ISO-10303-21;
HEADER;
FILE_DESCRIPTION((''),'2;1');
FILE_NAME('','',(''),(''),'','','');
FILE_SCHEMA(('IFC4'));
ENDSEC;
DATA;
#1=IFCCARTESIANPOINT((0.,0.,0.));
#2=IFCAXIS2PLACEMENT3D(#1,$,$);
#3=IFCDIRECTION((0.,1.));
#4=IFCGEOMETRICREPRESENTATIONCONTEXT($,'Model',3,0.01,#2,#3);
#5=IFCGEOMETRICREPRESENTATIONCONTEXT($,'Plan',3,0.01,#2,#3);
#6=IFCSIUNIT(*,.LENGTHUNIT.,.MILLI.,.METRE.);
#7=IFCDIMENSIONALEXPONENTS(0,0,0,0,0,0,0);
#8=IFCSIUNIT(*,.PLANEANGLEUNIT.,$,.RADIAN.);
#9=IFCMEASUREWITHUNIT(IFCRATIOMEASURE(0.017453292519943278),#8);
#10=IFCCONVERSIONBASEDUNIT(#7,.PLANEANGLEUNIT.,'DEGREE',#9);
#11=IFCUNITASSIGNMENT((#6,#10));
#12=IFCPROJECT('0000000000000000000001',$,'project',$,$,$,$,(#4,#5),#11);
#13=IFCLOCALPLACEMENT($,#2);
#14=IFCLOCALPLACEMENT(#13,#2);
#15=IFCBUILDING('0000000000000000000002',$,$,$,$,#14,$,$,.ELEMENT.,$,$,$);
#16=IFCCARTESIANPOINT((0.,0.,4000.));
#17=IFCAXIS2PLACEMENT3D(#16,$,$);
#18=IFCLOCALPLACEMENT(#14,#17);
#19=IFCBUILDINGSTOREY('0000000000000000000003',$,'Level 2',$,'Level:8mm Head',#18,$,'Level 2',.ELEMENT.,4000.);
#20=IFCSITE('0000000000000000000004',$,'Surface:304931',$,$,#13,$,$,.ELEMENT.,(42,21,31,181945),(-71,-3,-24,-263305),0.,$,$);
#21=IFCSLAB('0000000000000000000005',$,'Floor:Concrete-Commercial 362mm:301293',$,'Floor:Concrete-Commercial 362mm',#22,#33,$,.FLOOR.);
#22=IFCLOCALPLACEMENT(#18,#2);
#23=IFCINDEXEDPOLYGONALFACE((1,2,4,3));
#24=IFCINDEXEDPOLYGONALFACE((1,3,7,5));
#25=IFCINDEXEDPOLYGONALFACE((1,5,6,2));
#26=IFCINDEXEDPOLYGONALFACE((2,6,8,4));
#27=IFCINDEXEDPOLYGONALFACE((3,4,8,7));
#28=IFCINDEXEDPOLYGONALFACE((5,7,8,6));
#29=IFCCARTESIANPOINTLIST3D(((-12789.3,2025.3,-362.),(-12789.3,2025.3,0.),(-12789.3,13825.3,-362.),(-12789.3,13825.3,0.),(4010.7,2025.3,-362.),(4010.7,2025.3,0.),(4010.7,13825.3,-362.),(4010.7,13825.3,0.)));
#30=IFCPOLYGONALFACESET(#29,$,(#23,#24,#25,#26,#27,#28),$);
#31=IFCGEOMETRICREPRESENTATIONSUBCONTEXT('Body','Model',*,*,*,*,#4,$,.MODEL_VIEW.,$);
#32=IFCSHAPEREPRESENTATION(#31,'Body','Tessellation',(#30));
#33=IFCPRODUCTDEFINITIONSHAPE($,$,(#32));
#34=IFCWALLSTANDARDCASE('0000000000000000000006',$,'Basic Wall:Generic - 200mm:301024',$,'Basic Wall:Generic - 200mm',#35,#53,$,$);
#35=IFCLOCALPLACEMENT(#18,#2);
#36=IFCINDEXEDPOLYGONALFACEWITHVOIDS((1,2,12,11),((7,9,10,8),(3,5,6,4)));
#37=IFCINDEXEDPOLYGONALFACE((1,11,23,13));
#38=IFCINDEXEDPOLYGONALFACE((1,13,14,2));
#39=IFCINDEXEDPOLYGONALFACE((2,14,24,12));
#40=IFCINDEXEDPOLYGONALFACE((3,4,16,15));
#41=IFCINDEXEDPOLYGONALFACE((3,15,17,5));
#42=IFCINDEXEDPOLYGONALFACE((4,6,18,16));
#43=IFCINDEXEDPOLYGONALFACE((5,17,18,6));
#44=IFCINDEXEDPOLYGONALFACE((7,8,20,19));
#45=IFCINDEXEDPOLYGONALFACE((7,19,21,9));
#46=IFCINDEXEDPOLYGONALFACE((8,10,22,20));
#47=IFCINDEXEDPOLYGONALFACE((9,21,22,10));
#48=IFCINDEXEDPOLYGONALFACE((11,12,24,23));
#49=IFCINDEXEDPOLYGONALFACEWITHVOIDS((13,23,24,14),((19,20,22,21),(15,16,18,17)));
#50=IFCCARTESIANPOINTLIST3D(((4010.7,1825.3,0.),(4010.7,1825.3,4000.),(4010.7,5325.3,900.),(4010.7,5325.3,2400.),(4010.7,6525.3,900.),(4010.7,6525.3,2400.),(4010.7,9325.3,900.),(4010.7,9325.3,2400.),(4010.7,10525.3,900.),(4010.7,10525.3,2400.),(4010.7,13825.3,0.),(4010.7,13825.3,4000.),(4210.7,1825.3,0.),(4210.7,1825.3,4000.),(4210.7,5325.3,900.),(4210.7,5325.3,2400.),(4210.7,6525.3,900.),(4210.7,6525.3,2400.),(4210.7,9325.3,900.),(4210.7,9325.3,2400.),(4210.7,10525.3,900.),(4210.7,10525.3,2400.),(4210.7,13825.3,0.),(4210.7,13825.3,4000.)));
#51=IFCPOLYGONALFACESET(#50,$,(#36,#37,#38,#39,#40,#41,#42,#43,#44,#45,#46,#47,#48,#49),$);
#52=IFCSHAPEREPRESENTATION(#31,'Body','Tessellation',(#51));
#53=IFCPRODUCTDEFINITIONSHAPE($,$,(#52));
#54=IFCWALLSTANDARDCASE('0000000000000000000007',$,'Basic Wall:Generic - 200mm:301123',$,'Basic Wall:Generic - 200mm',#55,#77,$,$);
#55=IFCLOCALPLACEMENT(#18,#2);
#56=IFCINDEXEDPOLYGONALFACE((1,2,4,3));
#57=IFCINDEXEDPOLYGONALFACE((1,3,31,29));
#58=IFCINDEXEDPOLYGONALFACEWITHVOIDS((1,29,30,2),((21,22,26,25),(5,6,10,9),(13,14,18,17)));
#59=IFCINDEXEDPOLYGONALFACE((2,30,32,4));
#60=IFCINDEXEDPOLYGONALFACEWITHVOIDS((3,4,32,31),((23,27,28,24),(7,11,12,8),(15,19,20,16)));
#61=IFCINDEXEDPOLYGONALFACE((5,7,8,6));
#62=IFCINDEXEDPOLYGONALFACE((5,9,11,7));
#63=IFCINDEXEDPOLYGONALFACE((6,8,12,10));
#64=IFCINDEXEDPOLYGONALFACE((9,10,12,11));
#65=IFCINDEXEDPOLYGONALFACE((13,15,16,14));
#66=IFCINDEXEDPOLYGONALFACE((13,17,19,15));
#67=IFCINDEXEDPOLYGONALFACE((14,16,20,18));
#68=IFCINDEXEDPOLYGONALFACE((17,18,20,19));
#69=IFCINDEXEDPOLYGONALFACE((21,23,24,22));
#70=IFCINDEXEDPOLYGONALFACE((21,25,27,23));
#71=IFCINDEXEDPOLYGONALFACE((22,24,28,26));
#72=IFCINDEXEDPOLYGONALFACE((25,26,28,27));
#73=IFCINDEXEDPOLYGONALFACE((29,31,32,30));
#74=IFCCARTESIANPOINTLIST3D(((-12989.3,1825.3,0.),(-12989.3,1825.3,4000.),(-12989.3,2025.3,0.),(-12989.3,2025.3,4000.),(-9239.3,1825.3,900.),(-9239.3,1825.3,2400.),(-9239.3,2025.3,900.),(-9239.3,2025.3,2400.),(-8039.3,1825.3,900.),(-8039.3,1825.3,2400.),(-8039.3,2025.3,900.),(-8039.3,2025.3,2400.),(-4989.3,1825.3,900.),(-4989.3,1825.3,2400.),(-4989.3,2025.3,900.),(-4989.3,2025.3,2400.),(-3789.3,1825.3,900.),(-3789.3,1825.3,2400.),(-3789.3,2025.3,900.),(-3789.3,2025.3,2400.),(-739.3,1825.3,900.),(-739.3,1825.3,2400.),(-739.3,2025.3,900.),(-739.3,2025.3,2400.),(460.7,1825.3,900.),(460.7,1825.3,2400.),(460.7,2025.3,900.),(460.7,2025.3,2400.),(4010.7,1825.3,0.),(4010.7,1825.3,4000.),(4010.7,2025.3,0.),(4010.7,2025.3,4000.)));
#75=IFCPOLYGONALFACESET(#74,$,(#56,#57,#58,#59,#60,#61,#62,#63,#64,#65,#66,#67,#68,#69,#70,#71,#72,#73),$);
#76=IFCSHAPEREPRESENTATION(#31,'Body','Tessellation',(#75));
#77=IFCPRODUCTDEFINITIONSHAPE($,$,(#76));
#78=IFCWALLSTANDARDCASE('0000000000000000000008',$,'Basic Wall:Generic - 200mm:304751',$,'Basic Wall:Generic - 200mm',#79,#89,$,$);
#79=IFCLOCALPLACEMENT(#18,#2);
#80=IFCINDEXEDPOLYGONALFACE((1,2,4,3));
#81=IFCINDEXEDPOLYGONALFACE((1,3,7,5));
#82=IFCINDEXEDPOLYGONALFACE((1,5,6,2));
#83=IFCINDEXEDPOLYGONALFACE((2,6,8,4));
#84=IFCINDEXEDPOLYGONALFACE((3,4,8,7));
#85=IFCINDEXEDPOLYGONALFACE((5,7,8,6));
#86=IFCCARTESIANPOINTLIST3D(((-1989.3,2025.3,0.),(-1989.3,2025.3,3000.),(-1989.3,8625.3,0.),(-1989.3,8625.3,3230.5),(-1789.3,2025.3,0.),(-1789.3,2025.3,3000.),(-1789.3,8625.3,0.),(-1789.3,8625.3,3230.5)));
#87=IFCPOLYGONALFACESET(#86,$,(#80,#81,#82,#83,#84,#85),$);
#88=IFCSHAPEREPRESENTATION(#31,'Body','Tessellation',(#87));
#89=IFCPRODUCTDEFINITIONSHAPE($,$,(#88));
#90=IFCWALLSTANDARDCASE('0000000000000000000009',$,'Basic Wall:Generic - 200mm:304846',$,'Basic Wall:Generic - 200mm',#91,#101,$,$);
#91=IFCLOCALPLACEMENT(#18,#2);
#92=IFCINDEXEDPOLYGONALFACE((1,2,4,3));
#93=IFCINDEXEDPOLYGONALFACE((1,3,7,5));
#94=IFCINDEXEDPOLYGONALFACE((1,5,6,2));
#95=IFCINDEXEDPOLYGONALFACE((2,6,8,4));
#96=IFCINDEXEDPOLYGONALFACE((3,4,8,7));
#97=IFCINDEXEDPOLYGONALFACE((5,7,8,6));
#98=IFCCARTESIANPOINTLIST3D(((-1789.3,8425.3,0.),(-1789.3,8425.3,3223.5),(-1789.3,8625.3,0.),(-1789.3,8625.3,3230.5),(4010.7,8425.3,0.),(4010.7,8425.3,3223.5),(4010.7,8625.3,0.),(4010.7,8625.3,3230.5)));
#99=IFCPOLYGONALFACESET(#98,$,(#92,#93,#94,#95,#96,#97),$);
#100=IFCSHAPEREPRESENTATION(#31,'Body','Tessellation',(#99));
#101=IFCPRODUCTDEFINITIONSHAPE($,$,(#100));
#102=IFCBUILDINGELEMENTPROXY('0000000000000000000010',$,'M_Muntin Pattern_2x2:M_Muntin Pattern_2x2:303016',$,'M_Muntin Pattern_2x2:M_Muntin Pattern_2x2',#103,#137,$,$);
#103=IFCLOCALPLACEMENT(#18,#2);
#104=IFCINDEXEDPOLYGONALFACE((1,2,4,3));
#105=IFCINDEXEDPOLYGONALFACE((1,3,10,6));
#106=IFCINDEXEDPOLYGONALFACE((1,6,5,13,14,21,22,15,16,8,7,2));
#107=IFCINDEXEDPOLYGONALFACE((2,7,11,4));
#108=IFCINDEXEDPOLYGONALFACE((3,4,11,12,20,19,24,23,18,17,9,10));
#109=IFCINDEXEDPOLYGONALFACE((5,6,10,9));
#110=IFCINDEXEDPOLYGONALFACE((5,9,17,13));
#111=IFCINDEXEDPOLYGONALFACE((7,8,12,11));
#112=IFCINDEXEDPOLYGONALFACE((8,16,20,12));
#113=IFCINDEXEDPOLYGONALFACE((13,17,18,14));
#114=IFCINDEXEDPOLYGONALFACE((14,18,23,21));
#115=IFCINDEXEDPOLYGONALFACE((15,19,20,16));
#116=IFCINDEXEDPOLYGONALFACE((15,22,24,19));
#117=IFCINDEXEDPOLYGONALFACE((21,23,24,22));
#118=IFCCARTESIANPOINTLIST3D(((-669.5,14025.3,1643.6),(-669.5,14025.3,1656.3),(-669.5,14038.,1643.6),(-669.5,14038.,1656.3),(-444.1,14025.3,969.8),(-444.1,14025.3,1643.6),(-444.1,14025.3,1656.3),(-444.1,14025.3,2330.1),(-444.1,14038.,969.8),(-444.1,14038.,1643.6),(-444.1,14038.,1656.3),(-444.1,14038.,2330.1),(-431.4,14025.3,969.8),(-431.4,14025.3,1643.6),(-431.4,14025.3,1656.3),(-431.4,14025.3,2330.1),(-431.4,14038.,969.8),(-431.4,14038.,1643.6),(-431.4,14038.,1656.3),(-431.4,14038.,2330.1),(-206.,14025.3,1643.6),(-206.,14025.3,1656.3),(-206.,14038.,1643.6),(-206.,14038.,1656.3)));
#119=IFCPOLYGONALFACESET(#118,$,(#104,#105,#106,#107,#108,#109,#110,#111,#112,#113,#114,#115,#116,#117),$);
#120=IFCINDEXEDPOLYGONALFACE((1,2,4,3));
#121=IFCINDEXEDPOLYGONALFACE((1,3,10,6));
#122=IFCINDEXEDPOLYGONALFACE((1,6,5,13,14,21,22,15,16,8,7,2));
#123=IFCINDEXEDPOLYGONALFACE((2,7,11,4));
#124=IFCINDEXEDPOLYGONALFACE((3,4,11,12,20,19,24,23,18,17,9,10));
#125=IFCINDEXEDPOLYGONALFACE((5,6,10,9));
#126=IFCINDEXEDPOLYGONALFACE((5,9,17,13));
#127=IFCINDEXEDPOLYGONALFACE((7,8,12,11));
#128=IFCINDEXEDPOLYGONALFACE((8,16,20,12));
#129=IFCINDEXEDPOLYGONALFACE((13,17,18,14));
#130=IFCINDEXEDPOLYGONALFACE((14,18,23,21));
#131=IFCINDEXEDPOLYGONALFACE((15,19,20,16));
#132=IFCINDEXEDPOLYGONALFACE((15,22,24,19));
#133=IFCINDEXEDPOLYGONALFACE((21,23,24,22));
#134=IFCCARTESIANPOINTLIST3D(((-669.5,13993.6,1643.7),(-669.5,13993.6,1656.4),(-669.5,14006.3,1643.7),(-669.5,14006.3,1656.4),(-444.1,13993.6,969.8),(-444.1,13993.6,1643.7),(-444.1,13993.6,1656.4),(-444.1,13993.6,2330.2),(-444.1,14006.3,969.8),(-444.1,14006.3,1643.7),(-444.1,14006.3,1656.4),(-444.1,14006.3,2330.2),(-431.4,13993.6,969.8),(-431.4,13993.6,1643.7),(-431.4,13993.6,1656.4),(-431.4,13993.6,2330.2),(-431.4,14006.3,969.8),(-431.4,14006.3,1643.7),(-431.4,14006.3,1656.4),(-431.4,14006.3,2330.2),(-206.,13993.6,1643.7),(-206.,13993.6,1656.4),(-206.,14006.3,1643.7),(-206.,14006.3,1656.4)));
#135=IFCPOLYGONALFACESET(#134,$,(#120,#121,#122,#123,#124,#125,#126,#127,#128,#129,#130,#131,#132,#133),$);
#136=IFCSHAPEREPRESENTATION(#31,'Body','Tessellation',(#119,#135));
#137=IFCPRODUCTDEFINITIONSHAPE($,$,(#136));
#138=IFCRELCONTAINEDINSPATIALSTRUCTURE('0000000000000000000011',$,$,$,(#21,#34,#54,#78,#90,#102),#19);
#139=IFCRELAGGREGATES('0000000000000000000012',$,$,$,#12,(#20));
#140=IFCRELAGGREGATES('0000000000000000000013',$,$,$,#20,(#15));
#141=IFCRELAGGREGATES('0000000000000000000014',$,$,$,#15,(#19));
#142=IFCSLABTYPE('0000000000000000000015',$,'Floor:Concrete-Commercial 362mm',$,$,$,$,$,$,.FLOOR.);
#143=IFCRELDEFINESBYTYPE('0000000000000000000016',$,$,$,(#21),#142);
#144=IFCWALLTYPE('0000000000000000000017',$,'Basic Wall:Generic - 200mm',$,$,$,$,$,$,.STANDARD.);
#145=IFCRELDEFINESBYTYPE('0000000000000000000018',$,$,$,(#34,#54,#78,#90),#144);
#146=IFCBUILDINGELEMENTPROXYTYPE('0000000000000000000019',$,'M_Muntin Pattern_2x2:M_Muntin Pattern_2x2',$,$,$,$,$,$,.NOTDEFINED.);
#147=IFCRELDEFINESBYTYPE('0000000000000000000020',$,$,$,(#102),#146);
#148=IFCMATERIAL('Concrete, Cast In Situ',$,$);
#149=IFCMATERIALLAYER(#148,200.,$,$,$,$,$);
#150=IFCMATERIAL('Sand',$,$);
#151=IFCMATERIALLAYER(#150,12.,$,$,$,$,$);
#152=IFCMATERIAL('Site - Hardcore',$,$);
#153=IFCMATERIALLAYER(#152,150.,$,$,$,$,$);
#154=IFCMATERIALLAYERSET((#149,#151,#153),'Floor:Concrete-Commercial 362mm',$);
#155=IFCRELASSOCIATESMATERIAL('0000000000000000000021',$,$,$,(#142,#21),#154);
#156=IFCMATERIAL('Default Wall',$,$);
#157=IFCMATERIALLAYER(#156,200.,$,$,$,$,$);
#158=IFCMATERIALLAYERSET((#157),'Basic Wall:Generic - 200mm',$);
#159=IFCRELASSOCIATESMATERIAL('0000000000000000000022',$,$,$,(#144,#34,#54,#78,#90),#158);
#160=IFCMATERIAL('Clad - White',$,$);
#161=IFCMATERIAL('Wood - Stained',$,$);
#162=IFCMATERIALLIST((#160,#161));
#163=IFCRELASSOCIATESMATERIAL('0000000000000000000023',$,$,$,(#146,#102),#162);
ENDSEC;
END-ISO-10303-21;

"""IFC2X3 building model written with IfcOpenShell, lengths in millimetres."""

from ifc_helpers import new_model, entity, si_unit, converted_unit, direction, frame, frame_2d, origin, origin_2d_with_axis, place, context, subcontext, project, spatial, polyline, rectangle, outline, extrude, clip, bounded_halfspace, source, transform, mapped, material, material_list, layer, layer_set, layer_usage, type_object, type_shapes, element, save


model = new_model("IFC2X3")

# Units and contexts
model_context = context("Model", 3, precision=0.01, world=origin(), true_north=direction((0.0, 1.0)))
plan_context = context("Plan", 3, precision=0.01, world=origin(), true_north=direction((0.0, 1.0)))
body_context = subcontext(model_context, "Body", "Model", "MODEL_VIEW")
ifc_project = project(units=[si_unit("LENGTHUNIT", "METRE", prefix="MILLI"), converted_unit("PLANEANGLEUNIT", "DEGREE", entity("IfcRatioMeasure", 0.017453292519943278), si_unit("PLANEANGLEUNIT", "RADIAN"), dimensions=[0, 0, 0, 0, 0, 0, 0])], contexts=[model_context, plan_context])

# Site, building, storey
site_placement = place(None, origin())
site = spatial("IfcSite", under=ifc_project, at=site_placement, Name="Surface:304931", CompositionType="ELEMENT", RefLatitude=(42, 21, 31, 181945), RefLongitude=(-71, -3, -24, -263305), RefElevation=0.0)
building_placement = place(site_placement, origin())
building = spatial("IfcBuilding", under=site, at=building_placement, CompositionType="ELEMENT")
storey_placement = place(building_placement, frame((0.0, 0.0, 4000.0)))
storey = spatial("IfcBuildingStorey", under=building, at=storey_placement, Name="Level 2", ObjectType="Level:8mm Head", LongName="Level 2", CompositionType="ELEMENT", Elevation=4000.0)

# Slab
ifc_material_1 = material(Name="Concrete, Cast In Situ")
ifc_layer_1 = layer(ifc_material_1, 200.0)
ifc_material_2 = material(Name="Sand")
ifc_layer_2 = layer(ifc_material_2, 12.0)
ifc_material_3 = material(Name="Site - Hardcore")
ifc_layer_3 = layer(ifc_material_3, 150.0)
ifc_layer_set_1 = layer_set([ifc_layer_1, ifc_layer_2, ifc_layer_3], Name="Floor:Concrete-Commercial 362mm")
ifc_layer_usage_1 = layer_usage(ifc_layer_set_1, "AXIS3", "POSITIVE", 0.0)
slab_type = type_object("IfcSlabType", Name="Floor:Concrete-Commercial 362mm", PredefinedType="FLOOR", material=ifc_layer_set_1)
slab_placement = place(storey_placement, origin())
element("IfcSlab", 1, at=slab_placement, inside=storey, type_object=slab_type, material=ifc_layer_usage_1, Name="Floor:Concrete-Commercial 362mm:301293", ObjectType="Floor:Concrete-Commercial 362mm", PredefinedType="FLOOR", context=body_context, shape_type="SweptSolid", body=[
    extrude(rectangle(XDim=11800.0, YDim=16800.0, at=origin_2d_with_axis()), frame((-4389.3, 7925.3, 0.0), z_axis=(0.0, 0.0, -1.0), x_axis=(0.0, 1.0, 0.0)), (0.0, 0.0, 1.0), 362.0),
])

# Walls, openings
ifc_material_4 = material(Name="Default Wall")
ifc_layer_4 = layer(ifc_material_4, 200.0)
ifc_layer_set_2 = layer_set([ifc_layer_4], Name="Basic Wall:Generic - 200mm")
ifc_layer_usage_2 = layer_usage(ifc_layer_set_2, "AXIS2", "NEGATIVE", 100.0)
wall_type = type_object("IfcWallType", Name="Basic Wall:Generic - 200mm", PredefinedType="STANDARD", material=ifc_layer_set_2)
wall_1_placement = place(storey_placement, frame((4110.7, 13825.3, 0.0), z_axis=(0.0, 0.0, 1.0), x_axis=(0.0, -1.0, 0.0)))
wall_1 = element("IfcWallStandardCase", 2, at=wall_1_placement, inside=storey, type_object=wall_type, material=ifc_layer_usage_2, Name="Basic Wall:Generic - 200mm:301024", ObjectType="Basic Wall:Generic - 200mm", context=body_context, shape_type="SweptSolid", body=[
    extrude(rectangle(XDim=12000.0, YDim=200.0, at=frame_2d((6000.0, 0.0), x_axis=(-1.0, 0.0))), origin(), (0.0, 0.0, 1.0), 4000.0),
])
opening_1_placement = place(wall_1_placement, frame((3300.0, -100.0, 900.0)))
element("IfcOpeningElement", 3, at=opening_1_placement, cuts=wall_1, ObjectType="Opening", context=body_context, shape_type="SweptSolid", body=[
    extrude(rectangle(XDim=1500.0, YDim=1200.0, at=frame_2d((750.0, 600.0), x_axis=(-1.0, 0.0))), frame((0.0, 0.0, 0.0), z_axis=(0.0, 1.0, 0.0), x_axis=(0.0, 0.0, 1.0)), (0.0, 0.0, 1.0), 200.0),
])
opening_2_placement = place(wall_1_placement, frame((7300.0, -100.0, 900.0)))
element("IfcOpeningElement", 4, at=opening_2_placement, cuts=wall_1, ObjectType="Opening", context=body_context, shape_type="SweptSolid", body=[
    extrude(rectangle(XDim=1500.0, YDim=1200.0, at=frame_2d((750.0, 600.0), x_axis=(-1.0, 0.0))), frame((0.0, 0.0, 0.0), z_axis=(0.0, 1.0, 0.0), x_axis=(0.0, 0.0, 1.0)), (0.0, 0.0, 1.0), 200.0),
])
wall_2_placement = place(storey_placement, frame((4010.7, 1925.3, 0.0), z_axis=(0.0, 0.0, 1.0), x_axis=(-1.0, 0.0, 0.0)))
wall_2 = element("IfcWallStandardCase", 5, at=wall_2_placement, inside=storey, type_object=wall_type, material=ifc_layer_usage_2, Name="Basic Wall:Generic - 200mm:301123", ObjectType="Basic Wall:Generic - 200mm", context=body_context, shape_type="SweptSolid", body=[
    extrude(rectangle(XDim=17000.0, YDim=200.0, at=frame_2d((8500.0, 0.0), x_axis=(-1.0, 0.0))), origin(), (0.0, 0.0, 1.0), 4000.0),
])
opening_3_placement = place(wall_2_placement, frame((3550.0, -100.0, 900.0)))
element("IfcOpeningElement", 6, at=opening_3_placement, cuts=wall_2, ObjectType="Opening", context=body_context, shape_type="SweptSolid", body=[
    extrude(rectangle(XDim=1500.0, YDim=1200.0, at=frame_2d((750.0, 600.0), x_axis=(-1.0, 0.0))), frame((0.0, 0.0, 0.0), z_axis=(0.0, 1.0, 0.0), x_axis=(0.0, 0.0, 1.0)), (0.0, 0.0, 1.0), 200.0),
])
opening_4_placement = place(wall_2_placement, frame((7800.0, -100.0, 900.0)))
element("IfcOpeningElement", 7, at=opening_4_placement, cuts=wall_2, ObjectType="Opening", context=body_context, shape_type="SweptSolid", body=[
    extrude(rectangle(XDim=1500.0, YDim=1200.0, at=frame_2d((750.0, 600.0), x_axis=(-1.0, 0.0))), frame((0.0, 0.0, 0.0), z_axis=(0.0, 1.0, 0.0), x_axis=(0.0, 0.0, 1.0)), (0.0, 0.0, 1.0), 200.0),
])
opening_5_placement = place(wall_2_placement, frame((12050.0, -100.0, 900.0)))
element("IfcOpeningElement", 8, at=opening_5_placement, cuts=wall_2, ObjectType="Opening", context=body_context, shape_type="SweptSolid", body=[
    extrude(rectangle(XDim=1500.0, YDim=1200.0, at=frame_2d((750.0, 600.0), x_axis=(-1.0, 0.0))), frame((0.0, 0.0, 0.0), z_axis=(0.0, 1.0, 0.0), x_axis=(0.0, 0.0, 1.0)), (0.0, 0.0, 1.0), 200.0),
])

# Walls
wall_3_placement = place(storey_placement, frame((-1889.3, 2025.3, 0.0), z_axis=(0.0, 0.0, 1.0), x_axis=(0.0, 1.0, 0.0)))
element("IfcWallStandardCase", 9, at=wall_3_placement, inside=storey, type_object=wall_type, material=ifc_layer_usage_2, Name="Basic Wall:Generic - 200mm:304751", ObjectType="Basic Wall:Generic - 200mm", context=body_context, shape_type="Clipping", body=[
    clip(extrude(rectangle(XDim=6600.0, YDim=200.0, at=frame_2d((3300.0, 0.0), x_axis=(-1.0, 0.0))), origin(), (0.0, 0.0, 1.0), 3230.5), bounded_halfspace(frame((0.0, -100.0, 3000.0), z_axis=(-0.034899, 0.0, 0.999391), x_axis=(0.0, -1.0, 0.0)), False, frame((0.0, -100.0, 3000.0)), polyline([(0.0, 0.0), (6400.0, 0.0), (6600.0, 0.0), (6600.0, 200.0), (0.0, 200.0), (0.0, 0.0)]))),
])
wall_4_placement = place(storey_placement, frame((-1789.3, 8525.3, 0.0)))
element("IfcWallStandardCase", 10, at=wall_4_placement, inside=storey, type_object=wall_type, material=ifc_layer_usage_2, Name="Basic Wall:Generic - 200mm:304846", ObjectType="Basic Wall:Generic - 200mm", context=body_context, shape_type="Clipping", body=[
    clip(extrude(rectangle(XDim=5800.0, YDim=200.0, at=frame_2d((2900.0, 0.0), x_axis=(-1.0, 0.0))), origin(), (0.0, 0.0, 1.0), 3230.5), bounded_halfspace(frame((0.0, -100.0, 3223.5), z_axis=(0.0, -0.034899, 0.999391), x_axis=(1.0, 0.0, 0.0)), False, frame((0.0, -100.0, 3223.5)), polyline([(0.0, 0.0), (5800.0, 0.0), (5800.0, 200.0), (0.0, 200.0), (0.0, 0.0)]))),
])

# Building element proxy
ifc_material_5 = material(Name="Clad - White")
ifc_material_6 = material(Name="Wood - Stained")
ifc_material_list = material_list([ifc_material_5, ifc_material_6])
building_element_proxy_type_1 = type_object("IfcBuildingElementProxyType", Name="M_Muntin Pattern_2x2:M_Muntin Pattern_2x2", PredefinedType="NOTDEFINED", material=ifc_material_list)
shared_shape_1 = source(origin(), body_context, "Body", "SweptSolid", [
    extrude(outline(polyline([(6.4, -6.4), (680.1, -6.4), (680.1, 6.3), (6.4, 6.3), (6.4, 231.7), (-6.3, 231.7), (-6.3, 6.3), (-680.2, 6.3), (-680.2, -6.4), (-6.3, -6.4), (-6.3, -231.7), (6.4, -231.7), (6.4, -6.4)])), frame((0.0, 9.5, 680.1), z_axis=(0.0, 1.0, 0.0), x_axis=(0.0, 0.0, 1.0)), (0.0, 0.0, 1.0), 12.7),
    extrude(outline(polyline([(6.4, -6.4), (680.2, -6.4), (680.2, 6.3), (6.4, 6.3), (6.4, 231.7), (-6.3, 231.7), (-6.3, 6.3), (-680.2, 6.3), (-680.2, -6.4), (-6.3, -6.4), (-6.3, -231.7), (6.4, -231.7), (6.4, -6.4)])), frame((0.0, -22.2, 680.2), z_axis=(0.0, 1.0, 0.0), x_axis=(0.0, 0.0, 1.0)), (0.0, 0.0, 1.0), 12.7),
])
type_shapes(building_element_proxy_type_1, [shared_shape_1])
proxy_1_placement = place(storey_placement, frame((-437.7, 14015.8, 969.8)))
element("IfcBuildingElementProxy", 11, at=proxy_1_placement, inside=storey, type_object=building_element_proxy_type_1, material=ifc_material_list, Name="M_Muntin Pattern_2x2:M_Muntin Pattern_2x2:303016", ObjectType="M_Muntin Pattern_2x2:M_Muntin Pattern_2x2", context=body_context, shape_type="MappedRepresentation", body=[
    mapped(shared_shape_1, transform((0.0, 0.0, 0.0), scale=1.0)),
])

save(model, "model.ifc")
